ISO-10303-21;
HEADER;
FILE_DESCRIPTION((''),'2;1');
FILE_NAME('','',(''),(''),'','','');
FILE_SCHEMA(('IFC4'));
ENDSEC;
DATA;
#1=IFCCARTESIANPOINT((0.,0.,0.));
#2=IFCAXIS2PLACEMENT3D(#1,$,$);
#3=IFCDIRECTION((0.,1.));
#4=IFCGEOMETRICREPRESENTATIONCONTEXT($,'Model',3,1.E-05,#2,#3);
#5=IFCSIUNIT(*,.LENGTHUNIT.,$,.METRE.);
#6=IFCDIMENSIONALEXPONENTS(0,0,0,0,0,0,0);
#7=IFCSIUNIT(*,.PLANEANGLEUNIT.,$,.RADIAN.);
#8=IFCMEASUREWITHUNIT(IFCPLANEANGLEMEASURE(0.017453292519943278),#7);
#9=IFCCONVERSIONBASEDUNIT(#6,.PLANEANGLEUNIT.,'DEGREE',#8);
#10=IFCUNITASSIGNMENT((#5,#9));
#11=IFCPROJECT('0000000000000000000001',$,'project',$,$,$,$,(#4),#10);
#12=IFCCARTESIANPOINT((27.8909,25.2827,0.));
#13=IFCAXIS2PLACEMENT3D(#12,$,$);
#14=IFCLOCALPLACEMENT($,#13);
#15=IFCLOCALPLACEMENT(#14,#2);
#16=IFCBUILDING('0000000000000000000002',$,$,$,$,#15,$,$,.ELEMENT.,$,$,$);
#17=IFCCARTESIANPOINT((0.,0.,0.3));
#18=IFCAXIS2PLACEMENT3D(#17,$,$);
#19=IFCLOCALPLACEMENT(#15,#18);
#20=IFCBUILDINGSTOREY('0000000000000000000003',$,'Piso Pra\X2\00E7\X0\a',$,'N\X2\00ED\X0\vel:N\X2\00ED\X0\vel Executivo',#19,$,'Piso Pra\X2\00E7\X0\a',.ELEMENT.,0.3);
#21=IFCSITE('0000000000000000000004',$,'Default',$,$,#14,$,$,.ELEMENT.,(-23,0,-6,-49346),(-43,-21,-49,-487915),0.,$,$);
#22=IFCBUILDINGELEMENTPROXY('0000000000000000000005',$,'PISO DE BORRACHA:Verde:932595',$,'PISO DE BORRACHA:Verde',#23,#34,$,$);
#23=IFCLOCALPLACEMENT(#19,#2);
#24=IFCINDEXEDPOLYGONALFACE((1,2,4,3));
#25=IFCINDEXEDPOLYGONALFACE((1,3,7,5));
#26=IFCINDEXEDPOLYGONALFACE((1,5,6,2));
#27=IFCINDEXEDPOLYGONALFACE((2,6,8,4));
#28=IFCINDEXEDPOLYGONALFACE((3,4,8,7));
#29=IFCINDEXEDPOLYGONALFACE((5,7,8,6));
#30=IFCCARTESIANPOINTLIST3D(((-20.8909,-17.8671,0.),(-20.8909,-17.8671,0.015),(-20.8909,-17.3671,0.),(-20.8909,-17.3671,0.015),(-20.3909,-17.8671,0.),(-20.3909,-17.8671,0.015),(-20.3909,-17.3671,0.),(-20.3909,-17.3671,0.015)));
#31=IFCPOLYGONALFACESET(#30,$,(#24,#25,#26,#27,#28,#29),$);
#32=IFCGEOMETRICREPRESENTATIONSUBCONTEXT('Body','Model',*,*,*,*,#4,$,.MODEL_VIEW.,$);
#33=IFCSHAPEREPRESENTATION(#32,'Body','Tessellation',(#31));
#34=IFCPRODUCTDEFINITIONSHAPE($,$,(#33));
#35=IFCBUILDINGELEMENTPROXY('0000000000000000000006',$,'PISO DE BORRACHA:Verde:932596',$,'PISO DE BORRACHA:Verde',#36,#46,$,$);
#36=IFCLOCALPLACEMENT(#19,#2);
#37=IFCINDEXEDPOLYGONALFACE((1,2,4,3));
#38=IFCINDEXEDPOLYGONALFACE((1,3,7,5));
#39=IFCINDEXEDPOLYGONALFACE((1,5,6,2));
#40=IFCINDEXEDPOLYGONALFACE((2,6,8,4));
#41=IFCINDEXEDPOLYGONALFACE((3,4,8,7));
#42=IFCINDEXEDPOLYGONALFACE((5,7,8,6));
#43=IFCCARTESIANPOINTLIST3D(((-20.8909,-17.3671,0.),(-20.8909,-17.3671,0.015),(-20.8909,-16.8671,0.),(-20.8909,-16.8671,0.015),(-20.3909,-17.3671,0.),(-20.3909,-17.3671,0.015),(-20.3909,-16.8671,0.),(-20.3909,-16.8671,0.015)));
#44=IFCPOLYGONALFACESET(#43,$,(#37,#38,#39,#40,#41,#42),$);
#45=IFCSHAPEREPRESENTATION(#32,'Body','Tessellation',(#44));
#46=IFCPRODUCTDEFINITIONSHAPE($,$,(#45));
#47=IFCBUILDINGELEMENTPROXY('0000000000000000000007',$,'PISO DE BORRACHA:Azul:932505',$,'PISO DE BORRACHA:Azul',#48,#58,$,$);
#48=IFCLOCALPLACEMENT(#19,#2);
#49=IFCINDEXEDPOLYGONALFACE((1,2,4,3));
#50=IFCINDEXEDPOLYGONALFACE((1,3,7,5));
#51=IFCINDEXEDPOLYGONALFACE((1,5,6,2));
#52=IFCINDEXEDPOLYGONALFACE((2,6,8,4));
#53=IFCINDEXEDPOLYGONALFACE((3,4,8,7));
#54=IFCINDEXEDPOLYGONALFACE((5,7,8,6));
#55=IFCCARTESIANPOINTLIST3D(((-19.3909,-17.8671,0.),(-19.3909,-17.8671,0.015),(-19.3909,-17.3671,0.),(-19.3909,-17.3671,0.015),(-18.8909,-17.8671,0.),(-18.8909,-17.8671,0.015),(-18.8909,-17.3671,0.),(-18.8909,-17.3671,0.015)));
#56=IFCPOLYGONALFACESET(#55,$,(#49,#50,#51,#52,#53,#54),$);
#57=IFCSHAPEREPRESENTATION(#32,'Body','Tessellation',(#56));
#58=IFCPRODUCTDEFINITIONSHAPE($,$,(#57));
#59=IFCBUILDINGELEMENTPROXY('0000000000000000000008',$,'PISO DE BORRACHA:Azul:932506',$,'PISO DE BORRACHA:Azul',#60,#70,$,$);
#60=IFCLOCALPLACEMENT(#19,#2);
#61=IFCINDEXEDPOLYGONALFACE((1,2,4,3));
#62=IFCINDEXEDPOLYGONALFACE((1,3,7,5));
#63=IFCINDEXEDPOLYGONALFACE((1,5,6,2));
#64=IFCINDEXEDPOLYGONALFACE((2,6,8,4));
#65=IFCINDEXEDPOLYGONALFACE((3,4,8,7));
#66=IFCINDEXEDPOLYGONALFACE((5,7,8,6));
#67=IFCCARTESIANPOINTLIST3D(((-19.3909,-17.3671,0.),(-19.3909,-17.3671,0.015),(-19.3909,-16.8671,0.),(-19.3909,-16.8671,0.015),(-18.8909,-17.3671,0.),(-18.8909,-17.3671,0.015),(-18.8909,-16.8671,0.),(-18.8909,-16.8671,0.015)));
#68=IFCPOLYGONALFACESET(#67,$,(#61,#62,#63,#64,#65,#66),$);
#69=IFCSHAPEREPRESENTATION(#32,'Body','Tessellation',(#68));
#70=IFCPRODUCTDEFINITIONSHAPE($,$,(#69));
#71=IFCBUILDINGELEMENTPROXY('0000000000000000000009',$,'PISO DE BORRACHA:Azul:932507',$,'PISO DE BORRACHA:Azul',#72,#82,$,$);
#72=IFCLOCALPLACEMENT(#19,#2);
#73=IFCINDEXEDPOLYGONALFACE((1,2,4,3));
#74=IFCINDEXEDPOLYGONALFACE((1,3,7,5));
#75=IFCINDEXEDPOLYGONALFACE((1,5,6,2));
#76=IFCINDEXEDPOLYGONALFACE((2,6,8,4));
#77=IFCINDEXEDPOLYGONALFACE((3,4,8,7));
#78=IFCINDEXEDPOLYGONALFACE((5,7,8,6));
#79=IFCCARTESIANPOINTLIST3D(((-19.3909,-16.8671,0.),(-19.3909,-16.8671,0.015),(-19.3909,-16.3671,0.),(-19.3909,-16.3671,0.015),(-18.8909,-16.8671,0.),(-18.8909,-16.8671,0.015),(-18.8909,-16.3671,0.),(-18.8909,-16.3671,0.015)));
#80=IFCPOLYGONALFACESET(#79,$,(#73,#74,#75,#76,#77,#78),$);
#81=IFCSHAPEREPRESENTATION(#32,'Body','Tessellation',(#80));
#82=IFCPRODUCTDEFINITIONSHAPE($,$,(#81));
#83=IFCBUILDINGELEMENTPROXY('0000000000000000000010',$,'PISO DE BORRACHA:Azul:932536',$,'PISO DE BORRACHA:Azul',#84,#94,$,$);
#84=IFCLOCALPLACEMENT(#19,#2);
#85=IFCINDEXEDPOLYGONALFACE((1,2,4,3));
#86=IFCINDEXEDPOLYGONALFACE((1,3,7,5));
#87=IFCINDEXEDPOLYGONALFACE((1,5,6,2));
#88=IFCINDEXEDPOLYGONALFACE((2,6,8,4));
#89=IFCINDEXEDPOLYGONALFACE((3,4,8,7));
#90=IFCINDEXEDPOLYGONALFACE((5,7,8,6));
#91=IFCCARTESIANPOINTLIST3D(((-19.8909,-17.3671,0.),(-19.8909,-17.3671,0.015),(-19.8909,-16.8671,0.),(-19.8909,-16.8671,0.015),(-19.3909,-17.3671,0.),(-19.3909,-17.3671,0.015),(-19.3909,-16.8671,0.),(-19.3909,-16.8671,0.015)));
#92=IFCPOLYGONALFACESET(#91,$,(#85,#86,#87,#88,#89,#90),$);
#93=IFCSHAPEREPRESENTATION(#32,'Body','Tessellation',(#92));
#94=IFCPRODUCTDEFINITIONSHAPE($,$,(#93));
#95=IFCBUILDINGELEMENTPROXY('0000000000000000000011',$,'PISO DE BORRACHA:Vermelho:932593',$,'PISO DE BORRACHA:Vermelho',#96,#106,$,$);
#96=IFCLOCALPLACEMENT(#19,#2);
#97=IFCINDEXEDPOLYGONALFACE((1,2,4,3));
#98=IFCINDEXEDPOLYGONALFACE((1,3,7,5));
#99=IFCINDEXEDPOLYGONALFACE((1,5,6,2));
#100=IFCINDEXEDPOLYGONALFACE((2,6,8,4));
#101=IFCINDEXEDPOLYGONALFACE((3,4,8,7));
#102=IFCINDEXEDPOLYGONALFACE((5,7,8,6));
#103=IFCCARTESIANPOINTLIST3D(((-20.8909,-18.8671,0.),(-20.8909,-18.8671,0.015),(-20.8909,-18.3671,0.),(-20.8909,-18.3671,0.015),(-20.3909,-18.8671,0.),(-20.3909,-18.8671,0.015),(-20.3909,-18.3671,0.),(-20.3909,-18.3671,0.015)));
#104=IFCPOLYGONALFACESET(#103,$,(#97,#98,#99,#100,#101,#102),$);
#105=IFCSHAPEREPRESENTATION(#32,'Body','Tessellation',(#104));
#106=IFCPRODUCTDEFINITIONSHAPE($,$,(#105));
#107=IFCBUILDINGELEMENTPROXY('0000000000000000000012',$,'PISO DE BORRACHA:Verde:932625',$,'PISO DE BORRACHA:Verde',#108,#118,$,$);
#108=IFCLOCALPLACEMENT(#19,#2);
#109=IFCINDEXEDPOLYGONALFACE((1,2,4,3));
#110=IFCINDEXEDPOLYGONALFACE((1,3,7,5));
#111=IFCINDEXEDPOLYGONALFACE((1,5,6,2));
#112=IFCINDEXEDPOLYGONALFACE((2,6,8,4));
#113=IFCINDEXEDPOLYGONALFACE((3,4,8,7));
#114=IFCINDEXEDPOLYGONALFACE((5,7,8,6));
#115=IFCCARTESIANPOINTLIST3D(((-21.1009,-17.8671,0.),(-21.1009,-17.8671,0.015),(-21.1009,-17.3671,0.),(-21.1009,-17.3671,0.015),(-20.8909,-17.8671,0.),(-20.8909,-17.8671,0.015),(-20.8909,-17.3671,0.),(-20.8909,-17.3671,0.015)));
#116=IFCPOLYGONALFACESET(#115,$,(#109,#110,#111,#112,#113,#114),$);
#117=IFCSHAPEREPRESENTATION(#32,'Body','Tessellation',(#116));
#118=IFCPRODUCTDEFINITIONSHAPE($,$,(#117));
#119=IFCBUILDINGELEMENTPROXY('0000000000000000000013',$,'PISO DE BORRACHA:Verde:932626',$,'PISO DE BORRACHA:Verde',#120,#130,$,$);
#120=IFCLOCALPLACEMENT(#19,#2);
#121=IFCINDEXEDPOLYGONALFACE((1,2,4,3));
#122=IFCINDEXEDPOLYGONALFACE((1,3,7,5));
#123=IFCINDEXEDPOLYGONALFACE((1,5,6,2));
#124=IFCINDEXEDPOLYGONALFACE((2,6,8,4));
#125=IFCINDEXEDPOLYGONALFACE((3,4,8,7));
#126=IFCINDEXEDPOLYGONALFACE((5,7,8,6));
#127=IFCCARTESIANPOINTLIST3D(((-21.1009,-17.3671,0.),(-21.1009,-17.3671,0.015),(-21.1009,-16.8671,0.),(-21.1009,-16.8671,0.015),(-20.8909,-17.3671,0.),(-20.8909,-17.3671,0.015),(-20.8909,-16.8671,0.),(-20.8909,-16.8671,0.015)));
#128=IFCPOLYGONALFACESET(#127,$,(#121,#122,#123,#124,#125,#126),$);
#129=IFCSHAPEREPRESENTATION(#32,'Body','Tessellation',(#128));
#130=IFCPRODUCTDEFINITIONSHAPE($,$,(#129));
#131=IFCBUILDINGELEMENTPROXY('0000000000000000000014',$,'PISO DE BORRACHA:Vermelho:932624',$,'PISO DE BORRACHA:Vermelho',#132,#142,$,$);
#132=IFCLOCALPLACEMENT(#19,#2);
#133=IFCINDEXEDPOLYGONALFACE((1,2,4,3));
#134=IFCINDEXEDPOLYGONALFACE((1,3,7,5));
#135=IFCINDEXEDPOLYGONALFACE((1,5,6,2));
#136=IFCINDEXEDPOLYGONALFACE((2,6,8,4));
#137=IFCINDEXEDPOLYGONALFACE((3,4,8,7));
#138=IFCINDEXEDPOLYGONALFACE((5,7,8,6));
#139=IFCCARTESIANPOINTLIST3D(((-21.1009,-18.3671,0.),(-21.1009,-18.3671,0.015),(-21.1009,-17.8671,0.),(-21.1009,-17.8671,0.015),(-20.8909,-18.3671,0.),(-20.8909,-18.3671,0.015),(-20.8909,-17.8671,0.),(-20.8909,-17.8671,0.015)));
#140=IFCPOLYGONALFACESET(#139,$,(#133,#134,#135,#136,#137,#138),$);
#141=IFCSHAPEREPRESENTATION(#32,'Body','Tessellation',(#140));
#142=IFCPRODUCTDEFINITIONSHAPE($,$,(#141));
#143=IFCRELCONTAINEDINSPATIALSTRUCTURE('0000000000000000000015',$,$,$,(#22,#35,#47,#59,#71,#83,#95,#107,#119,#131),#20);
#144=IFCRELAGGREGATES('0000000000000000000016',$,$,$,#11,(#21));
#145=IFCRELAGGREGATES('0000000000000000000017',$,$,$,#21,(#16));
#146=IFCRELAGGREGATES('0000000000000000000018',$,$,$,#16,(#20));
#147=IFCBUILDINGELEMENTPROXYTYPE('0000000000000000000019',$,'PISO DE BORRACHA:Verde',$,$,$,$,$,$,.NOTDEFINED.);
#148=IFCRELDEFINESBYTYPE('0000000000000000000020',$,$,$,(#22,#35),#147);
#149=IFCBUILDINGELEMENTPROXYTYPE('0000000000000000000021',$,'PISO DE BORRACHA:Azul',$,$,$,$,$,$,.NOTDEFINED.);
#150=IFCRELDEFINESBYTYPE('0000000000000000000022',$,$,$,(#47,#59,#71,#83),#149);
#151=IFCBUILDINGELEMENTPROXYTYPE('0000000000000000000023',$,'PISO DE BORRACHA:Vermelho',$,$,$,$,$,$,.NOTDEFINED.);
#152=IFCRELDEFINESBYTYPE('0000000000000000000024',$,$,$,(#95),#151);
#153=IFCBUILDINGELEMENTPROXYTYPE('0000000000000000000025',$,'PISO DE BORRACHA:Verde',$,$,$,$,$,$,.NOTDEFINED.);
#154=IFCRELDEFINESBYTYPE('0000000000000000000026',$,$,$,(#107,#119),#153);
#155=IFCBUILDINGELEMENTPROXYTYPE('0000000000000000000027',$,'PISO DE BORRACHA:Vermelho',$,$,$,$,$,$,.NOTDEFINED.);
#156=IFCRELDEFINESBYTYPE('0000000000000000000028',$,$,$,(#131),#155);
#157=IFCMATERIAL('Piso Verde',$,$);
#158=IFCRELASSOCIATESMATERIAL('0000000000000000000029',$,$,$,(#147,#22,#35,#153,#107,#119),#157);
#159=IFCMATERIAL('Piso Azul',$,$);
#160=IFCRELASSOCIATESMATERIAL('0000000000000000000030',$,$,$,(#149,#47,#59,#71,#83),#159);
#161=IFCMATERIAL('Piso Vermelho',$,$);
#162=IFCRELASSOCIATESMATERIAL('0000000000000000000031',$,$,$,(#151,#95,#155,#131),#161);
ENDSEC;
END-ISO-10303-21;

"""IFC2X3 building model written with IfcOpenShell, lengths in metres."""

from ifc_helpers import new_model, entity, si_unit, converted_unit, direction, frame, origin, origin_2d_with_axis, place, context, subcontext, project, spatial, rectangle, extrude, source, transform, mapped, material, type_object, type_shapes, element, save


model = new_model("IFC2X3")

# Units and contexts
model_context = context("Model", 3, precision=1e-05, world=origin(), true_north=direction((0.0, 1.0)))
body_context = subcontext(model_context, "Body", "Model", "MODEL_VIEW")
ifc_project = project(units=[si_unit("LENGTHUNIT", "METRE"), converted_unit("PLANEANGLEUNIT", "DEGREE", entity("IfcPlaneAngleMeasure", 0.017453292519943278), si_unit("PLANEANGLEUNIT", "RADIAN"), dimensions=[0, 0, 0, 0, 0, 0, 0])], contexts=[model_context])

# Site, building, storey
site_placement = place(None, frame((27.8909, 25.2827, 0.0)))
site = spatial("IfcSite", under=ifc_project, at=site_placement, Name="Default", CompositionType="ELEMENT", RefLatitude=(-23, 0, -6, -49346), RefLongitude=(-43, -21, -49, -487915), RefElevation=0.0)
building_placement = place(site_placement, origin())
building = spatial("IfcBuilding", under=site, at=building_placement, CompositionType="ELEMENT")
storey_placement = place(building_placement, frame((0.0, 0.0, 0.3)))
storey = spatial("IfcBuildingStorey", under=building, at=storey_placement, Name="Piso Praça", ObjectType="Nível:Nível Executivo", LongName="Piso Praça", CompositionType="ELEMENT", Elevation=0.3)

# Building element proxies
ifc_material_1 = material(Name="Piso Verde")
building_element_proxy_type_1 = type_object("IfcBuildingElementProxyType", Name="PISO DE BORRACHA:Verde", PredefinedType="NOTDEFINED", material=ifc_material_1)
shared_shape_1 = source(origin(), body_context, "Body", "SweptSolid", [
    extrude(rectangle(XDim=0.5, YDim=0.5, at=origin_2d_with_axis()), frame((0.25, 0.25, 0.0), z_axis=(0.0, 0.0, 1.0), x_axis=(-1.0, 0.0, 0.0)), (0.0, 0.0, 1.0), 0.015),
])
type_shapes(building_element_proxy_type_1, [shared_shape_1])
for number, where, z_axis, x_axis, name in (
    (1, (-20.8909, -17.3671, 0.0), (0.0, 0.0, 1.0), (0.0, -1.0, 0.0), "PISO DE BORRACHA:Verde:932595"),
    (2, (-20.8909, -16.8671, 0.0), (0.0, 0.0, 1.0), (0.0, -1.0, 0.0), "PISO DE BORRACHA:Verde:932596"),
):
    element("IfcBuildingElementProxy", number, at=place(storey_placement, frame(where, z_axis=z_axis, x_axis=x_axis)), inside=storey, type_object=building_element_proxy_type_1, material=ifc_material_1, Name=name, ObjectType="PISO DE BORRACHA:Verde", context=body_context, shape_type="MappedRepresentation", body=[
        mapped(shared_shape_1, transform((0.0, 0.0, 0.0), scale=1.0)),
    ])
ifc_material_2 = material(Name="Piso Azul")
building_element_proxy_type_2 = type_object("IfcBuildingElementProxyType", Name="PISO DE BORRACHA:Azul", PredefinedType="NOTDEFINED", material=ifc_material_2)
shared_shape_2 = source(origin(), body_context, "Body", "SweptSolid", [
    extrude(rectangle(XDim=0.5, YDim=0.5, at=origin_2d_with_axis()), frame((0.25, 0.25, 0.0), z_axis=(0.0, 0.0, 1.0), x_axis=(-1.0, 0.0, 0.0)), (0.0, 0.0, 1.0), 0.015),
])
type_shapes(building_element_proxy_type_2, [shared_shape_2])
for number, where, z_axis, x_axis, name in (
    (3, (-19.3909, -17.3671, 0.0), (0.0, 0.0, 1.0), (0.0, -1.0, 0.0), "PISO DE BORRACHA:Azul:932505"),
    (4, (-19.3909, -16.8671, 0.0), (0.0, 0.0, 1.0), (0.0, -1.0, 0.0), "PISO DE BORRACHA:Azul:932506"),
    (5, (-19.3909, -16.3671, 0.0), (0.0, 0.0, 1.0), (0.0, -1.0, 0.0), "PISO DE BORRACHA:Azul:932507"),
    (6, (-19.8909, -16.8671, 0.0), (0.0, 0.0, 1.0), (0.0, -1.0, 0.0), "PISO DE BORRACHA:Azul:932536"),
):
    element("IfcBuildingElementProxy", number, at=place(storey_placement, frame(where, z_axis=z_axis, x_axis=x_axis)), inside=storey, type_object=building_element_proxy_type_2, material=ifc_material_2, Name=name, ObjectType="PISO DE BORRACHA:Azul", context=body_context, shape_type="MappedRepresentation", body=[
        mapped(shared_shape_2, transform((0.0, 0.0, 0.0), scale=1.0)),
    ])
ifc_material_3 = material(Name="Piso Vermelho")
building_element_proxy_type_3 = type_object("IfcBuildingElementProxyType", Name="PISO DE BORRACHA:Vermelho", PredefinedType="NOTDEFINED", material=ifc_material_3)
shared_shape_3 = source(origin(), body_context, "Body", "SweptSolid", [
    extrude(rectangle(XDim=0.5, YDim=0.5, at=origin_2d_with_axis()), frame((0.25, 0.25, 0.0), z_axis=(0.0, 0.0, 1.0), x_axis=(-1.0, 0.0, 0.0)), (0.0, 0.0, 1.0), 0.015),
])
type_shapes(building_element_proxy_type_3, [shared_shape_3])
proxy_1_placement = place(storey_placement, frame((-20.8909, -18.3671, 0.0), z_axis=(0.0, 0.0, 1.0), x_axis=(0.0, -1.0, 0.0)))
element("IfcBuildingElementProxy", 7, at=proxy_1_placement, inside=storey, type_object=building_element_proxy_type_3, material=ifc_material_3, Name="PISO DE BORRACHA:Vermelho:932593", ObjectType="PISO DE BORRACHA:Vermelho", context=body_context, shape_type="MappedRepresentation", body=[
    mapped(shared_shape_3, transform((0.0, 0.0, 0.0), scale=1.0)),
])
building_element_proxy_type_4 = type_object("IfcBuildingElementProxyType", Name="PISO DE BORRACHA:Verde", PredefinedType="NOTDEFINED", material=ifc_material_1)
shared_shape_4 = source(origin(), body_context, "Body", "SweptSolid", [
    extrude(rectangle(XDim=0.5, YDim=0.21, at=origin_2d_with_axis()), frame((0.25, 0.105, 0.0), z_axis=(0.0, 0.0, 1.0), x_axis=(-1.0, 0.0, 0.0)), (0.0, 0.0, 1.0), 0.015),
])
type_shapes(building_element_proxy_type_4, [shared_shape_4])
for number, where, z_axis, x_axis, name in (
    (8, (-21.1009, -17.3671, 0.0), (0.0, 0.0, 1.0), (0.0, -1.0, 0.0), "PISO DE BORRACHA:Verde:932625"),
    (9, (-21.1009, -16.8671, 0.0), (0.0, 0.0, 1.0), (0.0, -1.0, 0.0), "PISO DE BORRACHA:Verde:932626"),
):
    element("IfcBuildingElementProxy", number, at=place(storey_placement, frame(where, z_axis=z_axis, x_axis=x_axis)), inside=storey, type_object=building_element_proxy_type_4, material=ifc_material_1, Name=name, ObjectType="PISO DE BORRACHA:Verde", context=body_context, shape_type="MappedRepresentation", body=[
        mapped(shared_shape_4, transform((0.0, 0.0, 0.0), scale=1.0)),
    ])
building_element_proxy_type_5 = type_object("IfcBuildingElementProxyType", Name="PISO DE BORRACHA:Vermelho", PredefinedType="NOTDEFINED", material=ifc_material_3)
shared_shape_5 = source(origin(), body_context, "Body", "SweptSolid", [
    extrude(rectangle(XDim=0.5, YDim=0.21, at=origin_2d_with_axis()), frame((0.25, 0.105, 0.0), z_axis=(0.0, 0.0, 1.0), x_axis=(-1.0, 0.0, 0.0)), (0.0, 0.0, 1.0), 0.015),
])
type_shapes(building_element_proxy_type_5, [shared_shape_5])
proxy_2_placement = place(storey_placement, frame((-21.1009, -17.8671, 0.0), z_axis=(0.0, 0.0, 1.0), x_axis=(0.0, -1.0, 0.0)))
element("IfcBuildingElementProxy", 10, at=proxy_2_placement, inside=storey, type_object=building_element_proxy_type_5, material=ifc_material_3, Name="PISO DE BORRACHA:Vermelho:932624", ObjectType="PISO DE BORRACHA:Vermelho", context=body_context, shape_type="MappedRepresentation", body=[
    mapped(shared_shape_5, transform((0.0, 0.0, 0.0), scale=1.0)),
])

save(model, "model.ifc")
